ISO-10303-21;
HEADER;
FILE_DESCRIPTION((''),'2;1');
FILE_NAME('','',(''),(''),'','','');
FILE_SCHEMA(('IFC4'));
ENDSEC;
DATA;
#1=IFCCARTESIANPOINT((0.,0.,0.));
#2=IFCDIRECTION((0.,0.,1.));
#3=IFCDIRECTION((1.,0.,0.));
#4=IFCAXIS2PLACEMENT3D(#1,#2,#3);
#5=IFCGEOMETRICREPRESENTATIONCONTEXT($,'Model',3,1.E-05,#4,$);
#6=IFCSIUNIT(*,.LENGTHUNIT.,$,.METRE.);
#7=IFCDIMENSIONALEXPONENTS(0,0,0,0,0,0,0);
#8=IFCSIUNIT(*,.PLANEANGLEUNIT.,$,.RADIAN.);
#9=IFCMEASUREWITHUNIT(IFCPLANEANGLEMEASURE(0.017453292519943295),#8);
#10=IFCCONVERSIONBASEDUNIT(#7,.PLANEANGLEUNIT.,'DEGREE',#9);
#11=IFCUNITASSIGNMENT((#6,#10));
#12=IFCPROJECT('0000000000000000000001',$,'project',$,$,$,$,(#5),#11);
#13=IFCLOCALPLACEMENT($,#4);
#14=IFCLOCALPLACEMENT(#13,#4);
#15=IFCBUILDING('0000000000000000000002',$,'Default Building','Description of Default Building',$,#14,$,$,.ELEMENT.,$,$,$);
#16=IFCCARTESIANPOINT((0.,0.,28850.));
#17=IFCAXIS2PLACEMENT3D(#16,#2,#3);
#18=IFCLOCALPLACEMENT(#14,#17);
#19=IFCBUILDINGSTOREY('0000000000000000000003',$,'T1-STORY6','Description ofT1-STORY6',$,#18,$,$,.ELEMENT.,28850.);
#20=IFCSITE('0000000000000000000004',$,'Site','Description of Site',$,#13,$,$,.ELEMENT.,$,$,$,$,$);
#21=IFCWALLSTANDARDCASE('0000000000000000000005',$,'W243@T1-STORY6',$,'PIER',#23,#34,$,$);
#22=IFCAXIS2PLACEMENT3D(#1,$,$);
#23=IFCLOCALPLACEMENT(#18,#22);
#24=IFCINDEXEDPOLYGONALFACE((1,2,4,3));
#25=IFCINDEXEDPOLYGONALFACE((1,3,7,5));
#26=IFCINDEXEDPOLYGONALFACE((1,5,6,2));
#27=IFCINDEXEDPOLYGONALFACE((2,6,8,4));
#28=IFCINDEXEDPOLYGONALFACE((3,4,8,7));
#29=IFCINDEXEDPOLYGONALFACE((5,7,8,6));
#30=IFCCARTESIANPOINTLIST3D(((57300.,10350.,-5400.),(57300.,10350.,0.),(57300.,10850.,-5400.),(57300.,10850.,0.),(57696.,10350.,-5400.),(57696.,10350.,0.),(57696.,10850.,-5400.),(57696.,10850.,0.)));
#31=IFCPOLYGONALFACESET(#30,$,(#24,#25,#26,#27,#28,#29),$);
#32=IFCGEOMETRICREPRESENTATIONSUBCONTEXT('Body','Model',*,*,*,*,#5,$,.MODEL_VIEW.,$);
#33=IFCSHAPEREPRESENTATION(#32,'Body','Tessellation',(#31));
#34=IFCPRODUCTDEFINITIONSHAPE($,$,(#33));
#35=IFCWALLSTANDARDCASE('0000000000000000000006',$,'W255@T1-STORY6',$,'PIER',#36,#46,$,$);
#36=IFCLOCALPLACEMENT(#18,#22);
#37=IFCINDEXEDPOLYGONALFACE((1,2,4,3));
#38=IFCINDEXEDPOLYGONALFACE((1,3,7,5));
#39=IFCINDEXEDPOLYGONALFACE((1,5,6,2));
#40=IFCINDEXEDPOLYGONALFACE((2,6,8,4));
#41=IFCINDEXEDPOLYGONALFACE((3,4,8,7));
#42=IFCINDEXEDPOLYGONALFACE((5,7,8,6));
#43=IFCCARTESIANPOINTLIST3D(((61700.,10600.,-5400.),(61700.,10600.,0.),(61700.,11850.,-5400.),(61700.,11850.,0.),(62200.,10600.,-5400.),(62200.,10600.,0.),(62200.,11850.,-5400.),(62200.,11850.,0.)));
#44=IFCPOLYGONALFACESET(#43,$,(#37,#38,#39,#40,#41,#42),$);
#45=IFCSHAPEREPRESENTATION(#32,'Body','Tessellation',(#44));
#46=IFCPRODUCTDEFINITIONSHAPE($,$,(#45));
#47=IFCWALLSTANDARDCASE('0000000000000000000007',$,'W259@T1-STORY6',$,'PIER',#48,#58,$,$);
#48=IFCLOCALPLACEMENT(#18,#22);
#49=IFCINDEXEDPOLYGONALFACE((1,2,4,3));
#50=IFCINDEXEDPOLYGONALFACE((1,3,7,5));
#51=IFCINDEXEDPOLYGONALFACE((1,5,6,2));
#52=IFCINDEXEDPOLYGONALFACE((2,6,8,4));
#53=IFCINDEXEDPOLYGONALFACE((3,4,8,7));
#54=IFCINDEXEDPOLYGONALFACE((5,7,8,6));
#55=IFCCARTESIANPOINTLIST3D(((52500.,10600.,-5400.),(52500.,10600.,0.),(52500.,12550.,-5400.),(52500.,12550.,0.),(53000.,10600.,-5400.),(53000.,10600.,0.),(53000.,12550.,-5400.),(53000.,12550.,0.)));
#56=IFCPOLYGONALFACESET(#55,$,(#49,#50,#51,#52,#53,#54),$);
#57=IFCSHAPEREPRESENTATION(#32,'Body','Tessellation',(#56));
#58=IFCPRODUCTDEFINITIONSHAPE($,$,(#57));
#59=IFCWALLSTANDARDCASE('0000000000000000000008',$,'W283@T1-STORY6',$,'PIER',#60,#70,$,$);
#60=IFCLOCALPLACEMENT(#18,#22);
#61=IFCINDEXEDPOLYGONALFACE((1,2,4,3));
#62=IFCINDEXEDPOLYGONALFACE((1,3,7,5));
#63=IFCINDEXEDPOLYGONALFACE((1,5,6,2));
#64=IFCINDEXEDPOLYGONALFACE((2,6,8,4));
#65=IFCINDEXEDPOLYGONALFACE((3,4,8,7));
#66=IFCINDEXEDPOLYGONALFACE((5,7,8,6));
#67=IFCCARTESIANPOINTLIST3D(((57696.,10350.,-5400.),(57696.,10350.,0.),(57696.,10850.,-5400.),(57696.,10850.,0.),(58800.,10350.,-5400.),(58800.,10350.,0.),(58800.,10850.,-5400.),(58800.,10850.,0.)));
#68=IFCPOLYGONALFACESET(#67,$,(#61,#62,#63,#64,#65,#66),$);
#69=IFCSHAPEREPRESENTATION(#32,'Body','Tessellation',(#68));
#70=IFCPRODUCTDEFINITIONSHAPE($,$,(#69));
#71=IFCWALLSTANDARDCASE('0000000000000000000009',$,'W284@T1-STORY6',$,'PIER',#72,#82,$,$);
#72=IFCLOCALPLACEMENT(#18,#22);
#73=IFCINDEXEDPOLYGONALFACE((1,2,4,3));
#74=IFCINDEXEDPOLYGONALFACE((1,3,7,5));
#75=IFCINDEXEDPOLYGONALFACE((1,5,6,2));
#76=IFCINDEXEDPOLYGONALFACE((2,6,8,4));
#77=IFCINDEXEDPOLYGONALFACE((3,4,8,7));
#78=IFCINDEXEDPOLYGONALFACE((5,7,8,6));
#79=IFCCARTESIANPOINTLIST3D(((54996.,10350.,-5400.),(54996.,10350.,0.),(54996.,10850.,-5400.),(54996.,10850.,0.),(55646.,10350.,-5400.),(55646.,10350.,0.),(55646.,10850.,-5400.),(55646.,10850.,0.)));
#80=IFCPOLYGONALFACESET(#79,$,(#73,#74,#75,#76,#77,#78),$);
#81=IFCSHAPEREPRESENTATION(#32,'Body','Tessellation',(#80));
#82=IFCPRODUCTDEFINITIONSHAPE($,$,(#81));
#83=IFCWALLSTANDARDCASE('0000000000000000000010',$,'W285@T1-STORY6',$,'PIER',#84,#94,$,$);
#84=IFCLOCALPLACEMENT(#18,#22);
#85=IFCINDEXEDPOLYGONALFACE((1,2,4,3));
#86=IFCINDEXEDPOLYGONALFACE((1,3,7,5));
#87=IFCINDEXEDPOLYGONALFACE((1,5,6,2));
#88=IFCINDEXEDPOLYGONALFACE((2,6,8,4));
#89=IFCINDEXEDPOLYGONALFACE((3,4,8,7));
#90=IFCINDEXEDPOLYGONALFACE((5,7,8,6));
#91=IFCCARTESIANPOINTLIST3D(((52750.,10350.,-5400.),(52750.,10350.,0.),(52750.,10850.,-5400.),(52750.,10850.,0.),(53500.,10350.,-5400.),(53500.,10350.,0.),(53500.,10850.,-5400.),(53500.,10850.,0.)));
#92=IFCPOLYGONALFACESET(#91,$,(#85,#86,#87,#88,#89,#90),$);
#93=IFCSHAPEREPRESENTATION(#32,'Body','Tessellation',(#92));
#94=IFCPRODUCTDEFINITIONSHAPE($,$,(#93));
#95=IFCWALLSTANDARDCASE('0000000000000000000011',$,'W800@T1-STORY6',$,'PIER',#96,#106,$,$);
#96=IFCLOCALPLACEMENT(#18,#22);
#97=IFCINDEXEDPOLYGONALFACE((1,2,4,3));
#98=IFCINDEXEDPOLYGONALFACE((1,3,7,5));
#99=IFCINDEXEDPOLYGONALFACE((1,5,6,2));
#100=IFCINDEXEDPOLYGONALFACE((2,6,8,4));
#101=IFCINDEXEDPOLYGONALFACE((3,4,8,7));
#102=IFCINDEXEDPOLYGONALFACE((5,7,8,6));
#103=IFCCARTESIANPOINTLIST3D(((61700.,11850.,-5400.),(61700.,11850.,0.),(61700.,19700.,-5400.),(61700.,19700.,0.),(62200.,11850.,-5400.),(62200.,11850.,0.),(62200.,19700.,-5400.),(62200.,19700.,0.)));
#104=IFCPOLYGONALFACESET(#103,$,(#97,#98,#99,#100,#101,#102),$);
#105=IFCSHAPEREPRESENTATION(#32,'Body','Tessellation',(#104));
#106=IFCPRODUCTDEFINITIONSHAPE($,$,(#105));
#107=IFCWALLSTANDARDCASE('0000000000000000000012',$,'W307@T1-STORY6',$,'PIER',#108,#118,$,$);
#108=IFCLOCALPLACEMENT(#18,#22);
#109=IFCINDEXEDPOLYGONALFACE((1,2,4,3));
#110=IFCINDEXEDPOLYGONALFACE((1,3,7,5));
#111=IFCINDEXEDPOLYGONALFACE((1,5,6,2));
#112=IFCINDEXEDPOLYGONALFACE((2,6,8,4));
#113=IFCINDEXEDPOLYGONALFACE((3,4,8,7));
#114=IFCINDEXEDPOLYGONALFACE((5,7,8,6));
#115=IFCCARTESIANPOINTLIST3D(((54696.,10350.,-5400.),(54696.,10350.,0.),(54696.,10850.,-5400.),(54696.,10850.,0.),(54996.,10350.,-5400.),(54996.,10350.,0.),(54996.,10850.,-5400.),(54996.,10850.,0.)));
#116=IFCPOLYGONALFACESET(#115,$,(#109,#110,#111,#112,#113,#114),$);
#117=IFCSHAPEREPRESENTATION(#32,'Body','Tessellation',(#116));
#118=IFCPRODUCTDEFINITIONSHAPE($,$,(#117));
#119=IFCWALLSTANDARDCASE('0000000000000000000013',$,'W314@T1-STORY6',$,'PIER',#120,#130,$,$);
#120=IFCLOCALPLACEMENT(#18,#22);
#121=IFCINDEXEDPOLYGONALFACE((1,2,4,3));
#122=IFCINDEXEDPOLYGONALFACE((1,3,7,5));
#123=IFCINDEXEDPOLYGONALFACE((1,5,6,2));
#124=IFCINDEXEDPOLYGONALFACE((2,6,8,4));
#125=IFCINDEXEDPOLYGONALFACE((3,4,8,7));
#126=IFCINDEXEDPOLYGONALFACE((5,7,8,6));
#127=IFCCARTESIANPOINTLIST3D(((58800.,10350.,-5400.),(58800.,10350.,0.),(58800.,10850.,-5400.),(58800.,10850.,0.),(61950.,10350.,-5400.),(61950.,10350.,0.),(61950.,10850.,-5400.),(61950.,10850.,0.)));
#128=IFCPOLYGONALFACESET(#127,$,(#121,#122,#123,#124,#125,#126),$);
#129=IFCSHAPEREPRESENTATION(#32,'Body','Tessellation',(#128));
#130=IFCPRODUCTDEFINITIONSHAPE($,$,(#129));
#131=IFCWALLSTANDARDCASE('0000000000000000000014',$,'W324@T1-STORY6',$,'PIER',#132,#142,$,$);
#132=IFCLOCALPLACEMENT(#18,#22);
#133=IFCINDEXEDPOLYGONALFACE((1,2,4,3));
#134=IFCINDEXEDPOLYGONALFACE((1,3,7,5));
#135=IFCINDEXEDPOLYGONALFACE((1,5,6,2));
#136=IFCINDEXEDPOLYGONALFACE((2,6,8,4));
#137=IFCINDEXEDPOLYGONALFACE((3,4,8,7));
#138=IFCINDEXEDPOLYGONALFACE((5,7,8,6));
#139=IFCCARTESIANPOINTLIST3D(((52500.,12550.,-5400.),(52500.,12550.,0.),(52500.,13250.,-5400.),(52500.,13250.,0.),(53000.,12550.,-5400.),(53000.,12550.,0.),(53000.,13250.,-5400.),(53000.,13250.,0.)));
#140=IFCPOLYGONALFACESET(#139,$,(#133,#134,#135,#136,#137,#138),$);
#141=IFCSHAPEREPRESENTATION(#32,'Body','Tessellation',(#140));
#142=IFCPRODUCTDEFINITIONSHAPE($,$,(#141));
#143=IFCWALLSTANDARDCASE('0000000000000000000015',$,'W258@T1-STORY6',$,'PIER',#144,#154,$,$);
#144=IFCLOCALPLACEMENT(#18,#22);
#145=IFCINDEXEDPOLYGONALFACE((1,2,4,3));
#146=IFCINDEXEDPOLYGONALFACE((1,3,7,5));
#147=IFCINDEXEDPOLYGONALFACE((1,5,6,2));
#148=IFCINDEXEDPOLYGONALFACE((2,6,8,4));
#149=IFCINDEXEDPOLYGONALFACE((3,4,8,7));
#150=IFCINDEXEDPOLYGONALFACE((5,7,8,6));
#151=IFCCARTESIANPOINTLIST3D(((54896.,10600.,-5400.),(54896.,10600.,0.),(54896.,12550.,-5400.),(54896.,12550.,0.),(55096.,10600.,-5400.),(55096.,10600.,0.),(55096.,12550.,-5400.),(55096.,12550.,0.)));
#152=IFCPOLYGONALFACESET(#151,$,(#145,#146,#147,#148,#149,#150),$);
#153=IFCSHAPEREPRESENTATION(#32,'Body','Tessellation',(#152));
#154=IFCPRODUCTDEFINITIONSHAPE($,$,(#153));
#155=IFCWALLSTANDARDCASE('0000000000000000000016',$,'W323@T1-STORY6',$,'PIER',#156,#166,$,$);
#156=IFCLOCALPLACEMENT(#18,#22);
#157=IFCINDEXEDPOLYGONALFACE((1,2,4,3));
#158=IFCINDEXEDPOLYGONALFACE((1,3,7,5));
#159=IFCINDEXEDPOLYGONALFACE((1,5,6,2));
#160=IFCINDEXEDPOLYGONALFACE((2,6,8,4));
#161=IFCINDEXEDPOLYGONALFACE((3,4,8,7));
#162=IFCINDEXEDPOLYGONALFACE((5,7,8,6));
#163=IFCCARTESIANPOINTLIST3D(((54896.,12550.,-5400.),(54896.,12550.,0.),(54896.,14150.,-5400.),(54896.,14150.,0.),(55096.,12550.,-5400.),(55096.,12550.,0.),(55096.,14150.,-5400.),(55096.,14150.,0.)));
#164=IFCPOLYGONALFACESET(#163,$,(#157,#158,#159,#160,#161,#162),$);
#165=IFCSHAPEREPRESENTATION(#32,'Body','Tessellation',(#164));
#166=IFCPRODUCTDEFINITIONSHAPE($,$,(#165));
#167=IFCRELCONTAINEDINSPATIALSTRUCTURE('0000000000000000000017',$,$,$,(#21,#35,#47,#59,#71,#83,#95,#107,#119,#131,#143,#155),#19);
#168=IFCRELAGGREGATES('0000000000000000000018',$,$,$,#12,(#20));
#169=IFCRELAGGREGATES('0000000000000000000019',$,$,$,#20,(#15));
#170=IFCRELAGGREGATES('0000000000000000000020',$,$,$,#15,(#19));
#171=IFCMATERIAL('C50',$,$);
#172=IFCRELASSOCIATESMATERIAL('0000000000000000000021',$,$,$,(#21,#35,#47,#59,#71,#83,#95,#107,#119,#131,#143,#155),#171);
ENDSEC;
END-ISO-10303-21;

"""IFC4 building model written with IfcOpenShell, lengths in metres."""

from ifc_helpers import new_model, entity, si_unit, converted_unit, frame, origin_with_axes, place, context, subcontext, project, spatial, indexed_curve, outline, extrude, material, element, save


model = new_model("IFC4")

# Units and contexts
model_context = context("Model", 3, precision=1e-05, world=origin_with_axes())
body_context = subcontext(model_context, "Body", "Model", "MODEL_VIEW")
ifc_project = project(units=[si_unit("LENGTHUNIT", "METRE"), converted_unit("PLANEANGLEUNIT", "DEGREE", entity("IfcPlaneAngleMeasure", 0.017453292519943295), si_unit("PLANEANGLEUNIT", "RADIAN"), dimensions=[0, 0, 0, 0, 0, 0, 0])], contexts=[model_context])

# Site, building, storey
site_placement = place(None, origin_with_axes())
site = spatial("IfcSite", under=ifc_project, at=site_placement, Name="Site", Description="Description of Site", CompositionType="ELEMENT")
building_placement = place(site_placement, origin_with_axes())
building = spatial("IfcBuilding", under=site, at=building_placement, Name="Default Building", Description="Description of Default Building", CompositionType="ELEMENT")
storey_placement = place(building_placement, frame((0.0, 0.0, 28850.0), z_axis=(0.0, 0.0, 1.0), x_axis=(1.0, 0.0, 0.0)))
storey = spatial("IfcBuildingStorey", under=building, at=storey_placement, Name="T1-STORY6", Description="Description ofT1-STORY6", CompositionType="ELEMENT", Elevation=28850.0)

# Shared definitions
ifc_material_1 = material(Name="C50")

# Walls
wall_1_placement = place(storey_placement, frame((57300.0, 10600.0, -5400.0), z_axis=(0.0, 0.0, 1.0), x_axis=(1.0, 0.0, 0.0)))
element("IfcWallStandardCase", 1, at=wall_1_placement, inside=storey, material=ifc_material_1, Name="W243@T1-STORY6", ObjectType="PIER", context=body_context, shape_type="SweptSolid", body=[
    extrude(outline(indexed_curve([(0.0, -250.0), (0.0, 250.0), (396.0, 250.0), (396.0, -250.0), (0.0, -250.0)], self_intersect=False)), origin_with_axes(), (0.0, 0.0, 1.0), 5400.0),
])
wall_2_placement = place(storey_placement, frame((61950.0, 10600.0, -5400.0), z_axis=(0.0, 0.0, 1.0), x_axis=(0.0, 1.0, 0.0)))
element("IfcWallStandardCase", 2, at=wall_2_placement, inside=storey, material=ifc_material_1, Name="W255@T1-STORY6", ObjectType="PIER", context=body_context, shape_type="SweptSolid", body=[
    extrude(outline(indexed_curve([(0.0, -250.0), (0.0, 250.0), (1250.0, 250.0), (1250.0, -250.0), (0.0, -250.0)], self_intersect=False)), origin_with_axes(), (0.0, 0.0, 1.0), 5400.0),
])
wall_3_placement = place(storey_placement, frame((52750.0, 10600.0, -5400.0), z_axis=(0.0, 0.0, 1.0), x_axis=(0.0, 1.0, 0.0)))
element("IfcWallStandardCase", 3, at=wall_3_placement, inside=storey, material=ifc_material_1, Name="W259@T1-STORY6", ObjectType="PIER", context=body_context, shape_type="SweptSolid", body=[
    extrude(outline(indexed_curve([(0.0, -250.0), (0.0, 250.0), (1950.0, 250.0), (1950.0, -250.0), (0.0, -250.0)], self_intersect=False)), origin_with_axes(), (0.0, 0.0, 1.0), 5400.0),
])
wall_4_placement = place(storey_placement, frame((57696.0, 10600.0, -5400.0), z_axis=(0.0, 0.0, 1.0), x_axis=(1.0, 0.0, 0.0)))
element("IfcWallStandardCase", 4, at=wall_4_placement, inside=storey, material=ifc_material_1, Name="W283@T1-STORY6", ObjectType="PIER", context=body_context, shape_type="SweptSolid", body=[
    extrude(outline(indexed_curve([(0.0, -250.0), (0.0, 250.0), (1104.0, 250.0), (1104.0, -250.0), (0.0, -250.0)], self_intersect=False)), origin_with_axes(), (0.0, 0.0, 1.0), 5400.0),
])
wall_5_placement = place(storey_placement, frame((54996.0, 10600.0, -5400.0), z_axis=(0.0, 0.0, 1.0), x_axis=(1.0, 0.0, 0.0)))
element("IfcWallStandardCase", 5, at=wall_5_placement, inside=storey, material=ifc_material_1, Name="W284@T1-STORY6", ObjectType="PIER", context=body_context, shape_type="SweptSolid", body=[
    extrude(outline(indexed_curve([(0.0, -250.0), (0.0, 250.0), (650.0, 250.0), (650.0, -250.0), (0.0, -250.0)], self_intersect=False)), origin_with_axes(), (0.0, 0.0, 1.0), 5400.0),
])
wall_6_placement = place(storey_placement, frame((52750.0, 10600.0, -5400.0), z_axis=(0.0, 0.0, 1.0), x_axis=(1.0, 0.0, 0.0)))
element("IfcWallStandardCase", 6, at=wall_6_placement, inside=storey, material=ifc_material_1, Name="W285@T1-STORY6", ObjectType="PIER", context=body_context, shape_type="SweptSolid", body=[
    extrude(outline(indexed_curve([(0.0, -250.0), (0.0, 250.0), (750.0, 250.0), (750.0, -250.0), (0.0, -250.0)], self_intersect=False)), origin_with_axes(), (0.0, 0.0, 1.0), 5400.0),
])
wall_7_placement = place(storey_placement, frame((61950.0, 11850.0, -5400.0), z_axis=(0.0, 0.0, 1.0), x_axis=(0.0, 1.0, 0.0)))
element("IfcWallStandardCase", 7, at=wall_7_placement, inside=storey, material=ifc_material_1, Name="W800@T1-STORY6", ObjectType="PIER", context=body_context, shape_type="SweptSolid", body=[
    extrude(outline(indexed_curve([(0.0, -250.0), (0.0, 250.0), (7850.0, 250.0), (7850.0, -250.0), (0.0, -250.0)], self_intersect=False)), origin_with_axes(), (0.0, 0.0, 1.0), 5400.0),
])
wall_8_placement = place(storey_placement, frame((54696.0, 10600.0, -5400.0), z_axis=(0.0, 0.0, 1.0), x_axis=(1.0, 0.0, 0.0)))
element("IfcWallStandardCase", 8, at=wall_8_placement, inside=storey, material=ifc_material_1, Name="W307@T1-STORY6", ObjectType="PIER", context=body_context, shape_type="SweptSolid", body=[
    extrude(outline(indexed_curve([(0.0, -250.0), (0.0, 250.0), (300.0, 250.0), (300.0, -250.0), (0.0, -250.0)], self_intersect=False)), origin_with_axes(), (0.0, 0.0, 1.0), 5400.0),
])
wall_9_placement = place(storey_placement, frame((58800.0, 10600.0, -5400.0), z_axis=(0.0, 0.0, 1.0), x_axis=(1.0, 0.0, 0.0)))
element("IfcWallStandardCase", 9, at=wall_9_placement, inside=storey, material=ifc_material_1, Name="W314@T1-STORY6", ObjectType="PIER", context=body_context, shape_type="SweptSolid", body=[
    extrude(outline(indexed_curve([(0.0, -250.0), (0.0, 250.0), (3150.0, 250.0), (3150.0, -250.0), (0.0, -250.0)], self_intersect=False)), origin_with_axes(), (0.0, 0.0, 1.0), 5400.0),
])
wall_10_placement = place(storey_placement, frame((52750.0, 12550.0, -5400.0), z_axis=(0.0, 0.0, 1.0), x_axis=(0.0, 1.0, 0.0)))
element("IfcWallStandardCase", 10, at=wall_10_placement, inside=storey, material=ifc_material_1, Name="W324@T1-STORY6", ObjectType="PIER", context=body_context, shape_type="SweptSolid", body=[
    extrude(outline(indexed_curve([(0.0, -250.0), (0.0, 250.0), (700.0, 250.0), (700.0, -250.0), (0.0, -250.0)], self_intersect=False)), origin_with_axes(), (0.0, 0.0, 1.0), 5400.0),
])
wall_11_placement = place(storey_placement, frame((54996.0, 10600.0, -5400.0), z_axis=(0.0, 0.0, 1.0), x_axis=(0.0, 1.0, 0.0)))
element("IfcWallStandardCase", 11, at=wall_11_placement, inside=storey, material=ifc_material_1, Name="W258@T1-STORY6", ObjectType="PIER", context=body_context, shape_type="SweptSolid", body=[
    extrude(outline(indexed_curve([(0.0, -100.0), (0.0, 100.0), (1950.0, 100.0), (1950.0, -100.0), (0.0, -100.0)], self_intersect=False)), origin_with_axes(), (0.0, 0.0, 1.0), 5400.0),
])
wall_12_placement = place(storey_placement, frame((54996.0, 12550.0, -5400.0), z_axis=(0.0, 0.0, 1.0), x_axis=(0.0, 1.0, 0.0)))
element("IfcWallStandardCase", 12, at=wall_12_placement, inside=storey, material=ifc_material_1, Name="W323@T1-STORY6", ObjectType="PIER", context=body_context, shape_type="SweptSolid", body=[
    extrude(outline(indexed_curve([(0.0, -100.0), (0.0, 100.0), (1600.0, 100.0), (1600.0, -100.0), (0.0, -100.0)], self_intersect=False)), origin_with_axes(), (0.0, 0.0, 1.0), 5400.0),
])

save(model, "model.ifc")
